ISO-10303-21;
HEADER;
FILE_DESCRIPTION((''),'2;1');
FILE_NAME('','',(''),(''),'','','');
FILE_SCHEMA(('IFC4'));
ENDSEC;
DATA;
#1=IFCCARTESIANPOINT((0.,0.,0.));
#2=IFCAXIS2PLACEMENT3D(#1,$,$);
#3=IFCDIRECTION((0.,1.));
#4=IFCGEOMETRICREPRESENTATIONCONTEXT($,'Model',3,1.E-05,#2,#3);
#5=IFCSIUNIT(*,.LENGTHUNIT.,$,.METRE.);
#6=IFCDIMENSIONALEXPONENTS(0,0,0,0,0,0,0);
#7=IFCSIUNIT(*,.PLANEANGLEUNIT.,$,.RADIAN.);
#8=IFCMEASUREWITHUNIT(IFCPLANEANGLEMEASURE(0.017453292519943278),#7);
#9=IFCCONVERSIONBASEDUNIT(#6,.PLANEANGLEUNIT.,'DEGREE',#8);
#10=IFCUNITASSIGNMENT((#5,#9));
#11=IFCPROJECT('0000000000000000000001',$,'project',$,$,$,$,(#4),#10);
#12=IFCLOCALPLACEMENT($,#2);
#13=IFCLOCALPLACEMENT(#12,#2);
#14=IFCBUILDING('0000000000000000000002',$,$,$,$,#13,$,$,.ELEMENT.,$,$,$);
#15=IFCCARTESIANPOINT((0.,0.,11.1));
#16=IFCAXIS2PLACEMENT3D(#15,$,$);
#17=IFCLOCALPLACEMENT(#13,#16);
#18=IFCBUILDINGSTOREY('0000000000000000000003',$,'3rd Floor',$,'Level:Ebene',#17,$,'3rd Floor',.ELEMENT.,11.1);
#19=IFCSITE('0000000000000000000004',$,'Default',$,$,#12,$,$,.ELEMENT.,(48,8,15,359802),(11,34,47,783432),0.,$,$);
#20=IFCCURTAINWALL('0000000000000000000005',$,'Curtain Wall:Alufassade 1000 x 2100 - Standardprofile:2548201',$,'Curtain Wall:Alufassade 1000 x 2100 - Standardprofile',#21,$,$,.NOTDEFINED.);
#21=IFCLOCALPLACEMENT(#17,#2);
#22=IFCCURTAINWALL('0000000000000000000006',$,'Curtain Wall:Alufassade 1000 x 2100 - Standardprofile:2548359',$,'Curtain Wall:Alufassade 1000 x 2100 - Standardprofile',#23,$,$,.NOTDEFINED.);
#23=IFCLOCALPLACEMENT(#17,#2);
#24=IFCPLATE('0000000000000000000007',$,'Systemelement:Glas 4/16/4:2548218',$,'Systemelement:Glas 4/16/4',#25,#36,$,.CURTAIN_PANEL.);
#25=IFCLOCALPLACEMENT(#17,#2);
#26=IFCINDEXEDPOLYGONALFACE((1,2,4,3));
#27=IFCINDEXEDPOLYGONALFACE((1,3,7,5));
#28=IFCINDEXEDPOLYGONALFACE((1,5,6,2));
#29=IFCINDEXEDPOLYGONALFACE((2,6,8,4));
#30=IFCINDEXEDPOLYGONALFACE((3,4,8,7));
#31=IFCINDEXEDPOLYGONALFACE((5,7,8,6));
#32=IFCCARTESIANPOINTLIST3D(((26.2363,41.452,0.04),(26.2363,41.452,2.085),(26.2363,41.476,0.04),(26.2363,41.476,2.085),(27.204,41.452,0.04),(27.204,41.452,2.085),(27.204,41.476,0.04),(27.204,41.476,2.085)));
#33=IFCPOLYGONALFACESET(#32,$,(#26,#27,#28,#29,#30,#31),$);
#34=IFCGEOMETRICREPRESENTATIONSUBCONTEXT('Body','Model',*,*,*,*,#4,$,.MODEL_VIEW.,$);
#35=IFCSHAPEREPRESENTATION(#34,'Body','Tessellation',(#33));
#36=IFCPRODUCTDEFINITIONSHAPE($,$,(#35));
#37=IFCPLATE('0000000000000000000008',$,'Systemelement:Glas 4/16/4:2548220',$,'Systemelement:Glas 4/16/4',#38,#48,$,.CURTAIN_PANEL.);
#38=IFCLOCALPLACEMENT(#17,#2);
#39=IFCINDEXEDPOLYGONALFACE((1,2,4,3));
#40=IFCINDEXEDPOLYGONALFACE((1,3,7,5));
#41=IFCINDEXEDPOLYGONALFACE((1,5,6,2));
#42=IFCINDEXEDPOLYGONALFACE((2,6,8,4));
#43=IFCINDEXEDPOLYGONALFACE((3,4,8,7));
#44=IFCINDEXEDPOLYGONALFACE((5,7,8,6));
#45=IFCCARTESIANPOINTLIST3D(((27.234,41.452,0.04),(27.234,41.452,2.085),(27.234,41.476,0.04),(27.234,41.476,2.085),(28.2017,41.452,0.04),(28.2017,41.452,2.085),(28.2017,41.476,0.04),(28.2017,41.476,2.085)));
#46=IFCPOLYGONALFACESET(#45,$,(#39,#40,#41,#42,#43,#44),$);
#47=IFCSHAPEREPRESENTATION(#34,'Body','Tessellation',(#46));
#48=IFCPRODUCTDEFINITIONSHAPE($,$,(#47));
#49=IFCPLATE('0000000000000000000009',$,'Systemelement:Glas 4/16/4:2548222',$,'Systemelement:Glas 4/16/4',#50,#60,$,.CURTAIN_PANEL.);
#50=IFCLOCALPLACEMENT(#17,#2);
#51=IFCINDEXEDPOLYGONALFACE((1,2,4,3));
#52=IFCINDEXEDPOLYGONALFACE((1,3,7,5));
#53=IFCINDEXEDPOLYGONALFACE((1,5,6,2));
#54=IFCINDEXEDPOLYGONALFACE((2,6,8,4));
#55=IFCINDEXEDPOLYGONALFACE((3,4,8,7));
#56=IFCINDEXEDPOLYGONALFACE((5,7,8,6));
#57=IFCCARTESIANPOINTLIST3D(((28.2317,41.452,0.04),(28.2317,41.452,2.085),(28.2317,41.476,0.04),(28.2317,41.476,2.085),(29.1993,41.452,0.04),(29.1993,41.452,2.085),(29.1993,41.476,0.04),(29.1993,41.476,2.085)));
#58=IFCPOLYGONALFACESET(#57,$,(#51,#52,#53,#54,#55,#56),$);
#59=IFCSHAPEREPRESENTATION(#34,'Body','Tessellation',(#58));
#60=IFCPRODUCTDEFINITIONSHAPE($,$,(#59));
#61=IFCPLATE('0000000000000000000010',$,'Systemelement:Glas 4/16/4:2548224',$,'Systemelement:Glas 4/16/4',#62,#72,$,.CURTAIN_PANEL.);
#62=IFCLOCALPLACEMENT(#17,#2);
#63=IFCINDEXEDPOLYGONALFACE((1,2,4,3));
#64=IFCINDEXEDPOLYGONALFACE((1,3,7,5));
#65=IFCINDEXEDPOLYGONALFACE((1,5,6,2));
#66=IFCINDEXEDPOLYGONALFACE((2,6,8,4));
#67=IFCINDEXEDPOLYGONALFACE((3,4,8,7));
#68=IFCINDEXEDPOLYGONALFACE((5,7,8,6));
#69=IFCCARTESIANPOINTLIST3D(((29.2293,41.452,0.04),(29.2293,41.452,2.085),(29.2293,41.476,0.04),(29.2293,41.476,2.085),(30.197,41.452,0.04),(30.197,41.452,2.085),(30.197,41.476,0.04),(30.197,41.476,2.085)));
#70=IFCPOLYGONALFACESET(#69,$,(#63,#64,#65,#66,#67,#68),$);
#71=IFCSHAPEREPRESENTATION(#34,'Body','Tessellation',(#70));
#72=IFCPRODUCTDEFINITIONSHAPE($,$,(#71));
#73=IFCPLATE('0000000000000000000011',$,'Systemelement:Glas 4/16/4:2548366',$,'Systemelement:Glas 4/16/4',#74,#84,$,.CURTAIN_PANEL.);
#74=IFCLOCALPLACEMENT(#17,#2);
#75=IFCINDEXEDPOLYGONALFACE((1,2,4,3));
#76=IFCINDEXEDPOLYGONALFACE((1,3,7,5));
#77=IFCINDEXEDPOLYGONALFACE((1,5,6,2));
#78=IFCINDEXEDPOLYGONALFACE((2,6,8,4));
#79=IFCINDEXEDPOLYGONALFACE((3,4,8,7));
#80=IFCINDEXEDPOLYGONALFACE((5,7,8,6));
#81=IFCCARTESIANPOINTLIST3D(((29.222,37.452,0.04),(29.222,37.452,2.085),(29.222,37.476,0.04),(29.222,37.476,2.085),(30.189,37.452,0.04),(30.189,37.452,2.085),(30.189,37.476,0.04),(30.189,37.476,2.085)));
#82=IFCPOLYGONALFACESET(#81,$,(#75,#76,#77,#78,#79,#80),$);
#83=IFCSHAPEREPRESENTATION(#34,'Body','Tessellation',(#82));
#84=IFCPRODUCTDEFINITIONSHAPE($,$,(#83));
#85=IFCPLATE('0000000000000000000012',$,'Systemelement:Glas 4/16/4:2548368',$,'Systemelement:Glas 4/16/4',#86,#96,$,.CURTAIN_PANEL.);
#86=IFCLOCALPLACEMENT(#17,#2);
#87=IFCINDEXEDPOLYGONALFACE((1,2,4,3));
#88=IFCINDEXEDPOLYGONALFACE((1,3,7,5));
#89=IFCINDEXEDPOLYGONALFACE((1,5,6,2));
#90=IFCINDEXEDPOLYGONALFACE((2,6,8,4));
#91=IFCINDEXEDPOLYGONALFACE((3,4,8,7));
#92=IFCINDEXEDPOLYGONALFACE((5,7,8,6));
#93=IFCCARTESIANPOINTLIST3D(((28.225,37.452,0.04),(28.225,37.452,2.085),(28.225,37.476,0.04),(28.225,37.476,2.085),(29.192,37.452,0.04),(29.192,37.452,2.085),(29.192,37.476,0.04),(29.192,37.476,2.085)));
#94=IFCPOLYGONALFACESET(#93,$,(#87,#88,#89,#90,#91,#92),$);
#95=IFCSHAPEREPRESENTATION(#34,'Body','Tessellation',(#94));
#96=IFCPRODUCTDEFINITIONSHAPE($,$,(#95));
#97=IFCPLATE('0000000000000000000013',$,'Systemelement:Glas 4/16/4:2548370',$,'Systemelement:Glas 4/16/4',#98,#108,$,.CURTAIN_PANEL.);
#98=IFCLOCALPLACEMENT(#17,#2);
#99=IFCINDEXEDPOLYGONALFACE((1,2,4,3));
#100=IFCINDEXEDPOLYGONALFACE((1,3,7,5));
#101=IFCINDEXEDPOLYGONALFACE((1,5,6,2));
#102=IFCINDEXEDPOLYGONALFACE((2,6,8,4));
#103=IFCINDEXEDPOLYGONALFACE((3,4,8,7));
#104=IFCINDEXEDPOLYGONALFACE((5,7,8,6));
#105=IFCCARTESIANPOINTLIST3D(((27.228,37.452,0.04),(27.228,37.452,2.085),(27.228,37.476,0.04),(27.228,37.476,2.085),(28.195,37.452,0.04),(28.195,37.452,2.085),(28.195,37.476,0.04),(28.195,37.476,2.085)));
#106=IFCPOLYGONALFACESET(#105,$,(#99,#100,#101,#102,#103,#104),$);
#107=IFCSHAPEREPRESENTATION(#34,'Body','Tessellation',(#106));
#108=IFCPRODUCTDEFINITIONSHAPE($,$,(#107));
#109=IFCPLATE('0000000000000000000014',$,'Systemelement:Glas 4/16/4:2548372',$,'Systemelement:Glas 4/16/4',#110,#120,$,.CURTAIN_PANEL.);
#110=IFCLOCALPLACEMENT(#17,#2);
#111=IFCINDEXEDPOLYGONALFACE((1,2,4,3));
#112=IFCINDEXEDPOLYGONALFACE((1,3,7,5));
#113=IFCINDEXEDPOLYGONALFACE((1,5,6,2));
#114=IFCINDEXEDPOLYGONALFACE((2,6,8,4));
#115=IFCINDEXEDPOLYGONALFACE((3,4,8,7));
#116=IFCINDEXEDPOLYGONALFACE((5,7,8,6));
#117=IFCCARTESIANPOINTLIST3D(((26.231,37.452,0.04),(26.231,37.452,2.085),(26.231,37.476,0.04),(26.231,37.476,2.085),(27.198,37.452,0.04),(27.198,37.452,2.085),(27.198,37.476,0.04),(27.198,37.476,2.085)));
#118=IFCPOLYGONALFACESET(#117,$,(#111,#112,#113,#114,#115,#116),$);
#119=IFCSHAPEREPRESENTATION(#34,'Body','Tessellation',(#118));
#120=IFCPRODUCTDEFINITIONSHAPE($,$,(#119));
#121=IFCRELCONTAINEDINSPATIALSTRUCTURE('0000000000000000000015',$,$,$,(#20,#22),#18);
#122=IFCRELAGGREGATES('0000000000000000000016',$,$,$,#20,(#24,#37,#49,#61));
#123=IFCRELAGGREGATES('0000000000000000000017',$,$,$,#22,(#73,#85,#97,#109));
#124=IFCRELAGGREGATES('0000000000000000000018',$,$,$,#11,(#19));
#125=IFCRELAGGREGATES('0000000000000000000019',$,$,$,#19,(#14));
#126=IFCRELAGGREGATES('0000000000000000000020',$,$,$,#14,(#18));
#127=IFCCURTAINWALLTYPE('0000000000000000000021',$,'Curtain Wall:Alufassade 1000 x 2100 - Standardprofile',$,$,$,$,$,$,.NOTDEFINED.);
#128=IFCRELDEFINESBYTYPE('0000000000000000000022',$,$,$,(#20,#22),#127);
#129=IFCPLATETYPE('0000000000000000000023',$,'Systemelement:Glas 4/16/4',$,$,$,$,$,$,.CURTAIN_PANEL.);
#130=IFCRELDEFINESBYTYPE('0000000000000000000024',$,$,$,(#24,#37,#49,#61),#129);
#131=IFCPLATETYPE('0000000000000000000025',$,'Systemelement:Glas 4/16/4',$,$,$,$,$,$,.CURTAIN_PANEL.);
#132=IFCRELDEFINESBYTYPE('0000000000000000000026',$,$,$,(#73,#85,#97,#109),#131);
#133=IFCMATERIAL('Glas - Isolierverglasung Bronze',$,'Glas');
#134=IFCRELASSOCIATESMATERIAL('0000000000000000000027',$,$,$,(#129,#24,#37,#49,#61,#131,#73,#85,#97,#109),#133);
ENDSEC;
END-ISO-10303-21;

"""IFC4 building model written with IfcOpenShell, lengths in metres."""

from ifc_helpers import new_model, entity, si_unit, converted_unit, direction, frame, origin, place, context, subcontext, project, spatial, indexed_curve, outline, extrude, source, transform, mapped, material, type_object, type_shapes, element, aggregate, save


model = new_model("IFC4")

# Units and contexts
model_context = context("Model", 3, precision=1e-05, world=origin(), true_north=direction((0.0, 1.0)))
body_context = subcontext(model_context, "Body", "Model", "MODEL_VIEW")
ifc_project = project(units=[si_unit("LENGTHUNIT", "METRE"), converted_unit("PLANEANGLEUNIT", "DEGREE", entity("IfcPlaneAngleMeasure", 0.017453292519943278), si_unit("PLANEANGLEUNIT", "RADIAN"), dimensions=[0, 0, 0, 0, 0, 0, 0])], contexts=[model_context])

# Site, building, storey
site_placement = place(None, origin())
site = spatial("IfcSite", under=ifc_project, at=site_placement, Name="Default", CompositionType="ELEMENT", RefLatitude=(48, 8, 15, 359802), RefLongitude=(11, 34, 47, 783432), RefElevation=0.0)
building_placement = place(site_placement, origin())
building = spatial("IfcBuilding", under=site, at=building_placement, CompositionType="ELEMENT")
storey_placement = place(building_placement, frame((0.0, 0.0, 11.1)))
storey = spatial("IfcBuildingStorey", under=building, at=storey_placement, Name="3rd Floor", ObjectType="Level:Ebene", LongName="3rd Floor", CompositionType="ELEMENT", Elevation=11.1)

# Curtain walls
curtain_wall_type = type_object("IfcCurtainWallType", Name="Curtain Wall:Alufassade 1000 x 2100 - Standardprofile", PredefinedType="NOTDEFINED")
curtain_wall_1_placement = place(storey_placement, frame((0.0, 0.0, -11.1)))
curtain_wall_1 = element("IfcCurtainWall", 1, at=curtain_wall_1_placement, inside=storey, type_object=curtain_wall_type, Name="Curtain Wall:Alufassade 1000 x 2100 - Standardprofile:2548201", ObjectType="Curtain Wall:Alufassade 1000 x 2100 - Standardprofile", PredefinedType="NOTDEFINED")
curtain_wall_2_placement = place(storey_placement, frame((0.0, 0.0, -11.1)))
curtain_wall_2 = element("IfcCurtainWall", 2, at=curtain_wall_2_placement, inside=storey, type_object=curtain_wall_type, Name="Curtain Wall:Alufassade 1000 x 2100 - Standardprofile:2548359", ObjectType="Curtain Wall:Alufassade 1000 x 2100 - Standardprofile", PredefinedType="NOTDEFINED")

# Plates
ifc_material_1 = material(Name="Glas - Isolierverglasung Bronze", Category="Glas")
plate_type_1 = type_object("IfcPlateType", Name="Systemelement:Glas 4/16/4", PredefinedType="CURTAIN_PANEL", material=ifc_material_1)
shared_shape_1 = source(origin(), body_context, "Body", "SweptSolid", [
    extrude(outline(indexed_curve([(-0.012, -0.4838), (0.012, -0.4838), (0.012, 0.4838), (-0.012, 0.4838), (-0.012, -0.4838)], self_intersect=False)), frame((0.0, 0.0, 0.0), z_axis=(0.0, 0.0, 1.0), x_axis=(0.0, 1.0, 0.0)), (0.0, 0.0, 1.0), 2.045),
])
type_shapes(plate_type_1, [shared_shape_1])
plate_1_placement = place(curtain_wall_1_placement, frame((26.7202, 41.464, 11.14)))
plate_1 = element("IfcPlate", 3, at=plate_1_placement, type_object=plate_type_1, material=ifc_material_1, Name="Systemelement:Glas 4/16/4:2548218", ObjectType="Systemelement:Glas 4/16/4", PredefinedType="CURTAIN_PANEL", context=body_context, shape_type="MappedRepresentation", body=[
    mapped(shared_shape_1, transform((0.0, 0.0, 0.0), scale=1.0)),
])
plate_2_placement = place(curtain_wall_1_placement, frame((27.7178, 41.464, 11.14)))
plate_2 = element("IfcPlate", 4, at=plate_2_placement, type_object=plate_type_1, material=ifc_material_1, Name="Systemelement:Glas 4/16/4:2548220", ObjectType="Systemelement:Glas 4/16/4", PredefinedType="CURTAIN_PANEL", context=body_context, shape_type="MappedRepresentation", body=[
    mapped(shared_shape_1, transform((0.0, 0.0, 0.0), scale=1.0)),
])
plate_3_placement = place(curtain_wall_1_placement, frame((28.7155, 41.464, 11.14)))
plate_3 = element("IfcPlate", 5, at=plate_3_placement, type_object=plate_type_1, material=ifc_material_1, Name="Systemelement:Glas 4/16/4:2548222", ObjectType="Systemelement:Glas 4/16/4", PredefinedType="CURTAIN_PANEL", context=body_context, shape_type="MappedRepresentation", body=[
    mapped(shared_shape_1, transform((0.0, 0.0, 0.0), scale=1.0)),
])
plate_4_placement = place(curtain_wall_1_placement, frame((29.7132, 41.464, 11.14)))
plate_4 = element("IfcPlate", 6, at=plate_4_placement, type_object=plate_type_1, material=ifc_material_1, Name="Systemelement:Glas 4/16/4:2548224", ObjectType="Systemelement:Glas 4/16/4", PredefinedType="CURTAIN_PANEL", context=body_context, shape_type="MappedRepresentation", body=[
    mapped(shared_shape_1, transform((0.0, 0.0, 0.0), scale=1.0)),
])
aggregate(curtain_wall_1, [plate_1, plate_2, plate_3, plate_4])
plate_type_2 = type_object("IfcPlateType", Name="Systemelement:Glas 4/16/4", PredefinedType="CURTAIN_PANEL", material=ifc_material_1)
shared_shape_2 = source(origin(), body_context, "Body", "SweptSolid", [
    extrude(outline(indexed_curve([(-0.012, -0.4835), (0.012, -0.4835), (0.012, 0.4835), (-0.012, 0.4835), (-0.012, -0.4835)], self_intersect=False)), frame((0.0, 0.0, 0.0), z_axis=(0.0, 0.0, 1.0), x_axis=(0.0, 1.0, 0.0)), (0.0, 0.0, 1.0), 2.045),
])
type_shapes(plate_type_2, [shared_shape_2])
plate_5_placement = place(curtain_wall_2_placement, frame((29.7055, 37.464, 11.14), z_axis=(0.0, 0.0, 1.0), x_axis=(-1.0, 0.0, 0.0)))
plate_5 = element("IfcPlate", 7, at=plate_5_placement, type_object=plate_type_2, material=ifc_material_1, Name="Systemelement:Glas 4/16/4:2548366", ObjectType="Systemelement:Glas 4/16/4", PredefinedType="CURTAIN_PANEL", context=body_context, shape_type="MappedRepresentation", body=[
    mapped(shared_shape_2, transform((0.0, 0.0, 0.0), scale=1.0)),
])
plate_6_placement = place(curtain_wall_2_placement, frame((28.7085, 37.464, 11.14), z_axis=(0.0, 0.0, 1.0), x_axis=(-1.0, 0.0, 0.0)))
plate_6 = element("IfcPlate", 8, at=plate_6_placement, type_object=plate_type_2, material=ifc_material_1, Name="Systemelement:Glas 4/16/4:2548368", ObjectType="Systemelement:Glas 4/16/4", PredefinedType="CURTAIN_PANEL", context=body_context, shape_type="MappedRepresentation", body=[
    mapped(shared_shape_2, transform((0.0, 0.0, 0.0), scale=1.0)),
])
plate_7_placement = place(curtain_wall_2_placement, frame((27.7115, 37.464, 11.14), z_axis=(0.0, 0.0, 1.0), x_axis=(-1.0, 0.0, 0.0)))
plate_7 = element("IfcPlate", 9, at=plate_7_placement, type_object=plate_type_2, material=ifc_material_1, Name="Systemelement:Glas 4/16/4:2548370", ObjectType="Systemelement:Glas 4/16/4", PredefinedType="CURTAIN_PANEL", context=body_context, shape_type="MappedRepresentation", body=[
    mapped(shared_shape_2, transform((0.0, 0.0, 0.0), scale=1.0)),
])
plate_8_placement = place(curtain_wall_2_placement, frame((26.7145, 37.464, 11.14), z_axis=(0.0, 0.0, 1.0), x_axis=(-1.0, 0.0, 0.0)))
plate_8 = element("IfcPlate", 10, at=plate_8_placement, type_object=plate_type_2, material=ifc_material_1, Name="Systemelement:Glas 4/16/4:2548372", ObjectType="Systemelement:Glas 4/16/4", PredefinedType="CURTAIN_PANEL", context=body_context, shape_type="MappedRepresentation", body=[
    mapped(shared_shape_2, transform((0.0, 0.0, 0.0), scale=1.0)),
])
aggregate(curtain_wall_2, [plate_5, plate_6, plate_7, plate_8])

save(model, "model.ifc")
